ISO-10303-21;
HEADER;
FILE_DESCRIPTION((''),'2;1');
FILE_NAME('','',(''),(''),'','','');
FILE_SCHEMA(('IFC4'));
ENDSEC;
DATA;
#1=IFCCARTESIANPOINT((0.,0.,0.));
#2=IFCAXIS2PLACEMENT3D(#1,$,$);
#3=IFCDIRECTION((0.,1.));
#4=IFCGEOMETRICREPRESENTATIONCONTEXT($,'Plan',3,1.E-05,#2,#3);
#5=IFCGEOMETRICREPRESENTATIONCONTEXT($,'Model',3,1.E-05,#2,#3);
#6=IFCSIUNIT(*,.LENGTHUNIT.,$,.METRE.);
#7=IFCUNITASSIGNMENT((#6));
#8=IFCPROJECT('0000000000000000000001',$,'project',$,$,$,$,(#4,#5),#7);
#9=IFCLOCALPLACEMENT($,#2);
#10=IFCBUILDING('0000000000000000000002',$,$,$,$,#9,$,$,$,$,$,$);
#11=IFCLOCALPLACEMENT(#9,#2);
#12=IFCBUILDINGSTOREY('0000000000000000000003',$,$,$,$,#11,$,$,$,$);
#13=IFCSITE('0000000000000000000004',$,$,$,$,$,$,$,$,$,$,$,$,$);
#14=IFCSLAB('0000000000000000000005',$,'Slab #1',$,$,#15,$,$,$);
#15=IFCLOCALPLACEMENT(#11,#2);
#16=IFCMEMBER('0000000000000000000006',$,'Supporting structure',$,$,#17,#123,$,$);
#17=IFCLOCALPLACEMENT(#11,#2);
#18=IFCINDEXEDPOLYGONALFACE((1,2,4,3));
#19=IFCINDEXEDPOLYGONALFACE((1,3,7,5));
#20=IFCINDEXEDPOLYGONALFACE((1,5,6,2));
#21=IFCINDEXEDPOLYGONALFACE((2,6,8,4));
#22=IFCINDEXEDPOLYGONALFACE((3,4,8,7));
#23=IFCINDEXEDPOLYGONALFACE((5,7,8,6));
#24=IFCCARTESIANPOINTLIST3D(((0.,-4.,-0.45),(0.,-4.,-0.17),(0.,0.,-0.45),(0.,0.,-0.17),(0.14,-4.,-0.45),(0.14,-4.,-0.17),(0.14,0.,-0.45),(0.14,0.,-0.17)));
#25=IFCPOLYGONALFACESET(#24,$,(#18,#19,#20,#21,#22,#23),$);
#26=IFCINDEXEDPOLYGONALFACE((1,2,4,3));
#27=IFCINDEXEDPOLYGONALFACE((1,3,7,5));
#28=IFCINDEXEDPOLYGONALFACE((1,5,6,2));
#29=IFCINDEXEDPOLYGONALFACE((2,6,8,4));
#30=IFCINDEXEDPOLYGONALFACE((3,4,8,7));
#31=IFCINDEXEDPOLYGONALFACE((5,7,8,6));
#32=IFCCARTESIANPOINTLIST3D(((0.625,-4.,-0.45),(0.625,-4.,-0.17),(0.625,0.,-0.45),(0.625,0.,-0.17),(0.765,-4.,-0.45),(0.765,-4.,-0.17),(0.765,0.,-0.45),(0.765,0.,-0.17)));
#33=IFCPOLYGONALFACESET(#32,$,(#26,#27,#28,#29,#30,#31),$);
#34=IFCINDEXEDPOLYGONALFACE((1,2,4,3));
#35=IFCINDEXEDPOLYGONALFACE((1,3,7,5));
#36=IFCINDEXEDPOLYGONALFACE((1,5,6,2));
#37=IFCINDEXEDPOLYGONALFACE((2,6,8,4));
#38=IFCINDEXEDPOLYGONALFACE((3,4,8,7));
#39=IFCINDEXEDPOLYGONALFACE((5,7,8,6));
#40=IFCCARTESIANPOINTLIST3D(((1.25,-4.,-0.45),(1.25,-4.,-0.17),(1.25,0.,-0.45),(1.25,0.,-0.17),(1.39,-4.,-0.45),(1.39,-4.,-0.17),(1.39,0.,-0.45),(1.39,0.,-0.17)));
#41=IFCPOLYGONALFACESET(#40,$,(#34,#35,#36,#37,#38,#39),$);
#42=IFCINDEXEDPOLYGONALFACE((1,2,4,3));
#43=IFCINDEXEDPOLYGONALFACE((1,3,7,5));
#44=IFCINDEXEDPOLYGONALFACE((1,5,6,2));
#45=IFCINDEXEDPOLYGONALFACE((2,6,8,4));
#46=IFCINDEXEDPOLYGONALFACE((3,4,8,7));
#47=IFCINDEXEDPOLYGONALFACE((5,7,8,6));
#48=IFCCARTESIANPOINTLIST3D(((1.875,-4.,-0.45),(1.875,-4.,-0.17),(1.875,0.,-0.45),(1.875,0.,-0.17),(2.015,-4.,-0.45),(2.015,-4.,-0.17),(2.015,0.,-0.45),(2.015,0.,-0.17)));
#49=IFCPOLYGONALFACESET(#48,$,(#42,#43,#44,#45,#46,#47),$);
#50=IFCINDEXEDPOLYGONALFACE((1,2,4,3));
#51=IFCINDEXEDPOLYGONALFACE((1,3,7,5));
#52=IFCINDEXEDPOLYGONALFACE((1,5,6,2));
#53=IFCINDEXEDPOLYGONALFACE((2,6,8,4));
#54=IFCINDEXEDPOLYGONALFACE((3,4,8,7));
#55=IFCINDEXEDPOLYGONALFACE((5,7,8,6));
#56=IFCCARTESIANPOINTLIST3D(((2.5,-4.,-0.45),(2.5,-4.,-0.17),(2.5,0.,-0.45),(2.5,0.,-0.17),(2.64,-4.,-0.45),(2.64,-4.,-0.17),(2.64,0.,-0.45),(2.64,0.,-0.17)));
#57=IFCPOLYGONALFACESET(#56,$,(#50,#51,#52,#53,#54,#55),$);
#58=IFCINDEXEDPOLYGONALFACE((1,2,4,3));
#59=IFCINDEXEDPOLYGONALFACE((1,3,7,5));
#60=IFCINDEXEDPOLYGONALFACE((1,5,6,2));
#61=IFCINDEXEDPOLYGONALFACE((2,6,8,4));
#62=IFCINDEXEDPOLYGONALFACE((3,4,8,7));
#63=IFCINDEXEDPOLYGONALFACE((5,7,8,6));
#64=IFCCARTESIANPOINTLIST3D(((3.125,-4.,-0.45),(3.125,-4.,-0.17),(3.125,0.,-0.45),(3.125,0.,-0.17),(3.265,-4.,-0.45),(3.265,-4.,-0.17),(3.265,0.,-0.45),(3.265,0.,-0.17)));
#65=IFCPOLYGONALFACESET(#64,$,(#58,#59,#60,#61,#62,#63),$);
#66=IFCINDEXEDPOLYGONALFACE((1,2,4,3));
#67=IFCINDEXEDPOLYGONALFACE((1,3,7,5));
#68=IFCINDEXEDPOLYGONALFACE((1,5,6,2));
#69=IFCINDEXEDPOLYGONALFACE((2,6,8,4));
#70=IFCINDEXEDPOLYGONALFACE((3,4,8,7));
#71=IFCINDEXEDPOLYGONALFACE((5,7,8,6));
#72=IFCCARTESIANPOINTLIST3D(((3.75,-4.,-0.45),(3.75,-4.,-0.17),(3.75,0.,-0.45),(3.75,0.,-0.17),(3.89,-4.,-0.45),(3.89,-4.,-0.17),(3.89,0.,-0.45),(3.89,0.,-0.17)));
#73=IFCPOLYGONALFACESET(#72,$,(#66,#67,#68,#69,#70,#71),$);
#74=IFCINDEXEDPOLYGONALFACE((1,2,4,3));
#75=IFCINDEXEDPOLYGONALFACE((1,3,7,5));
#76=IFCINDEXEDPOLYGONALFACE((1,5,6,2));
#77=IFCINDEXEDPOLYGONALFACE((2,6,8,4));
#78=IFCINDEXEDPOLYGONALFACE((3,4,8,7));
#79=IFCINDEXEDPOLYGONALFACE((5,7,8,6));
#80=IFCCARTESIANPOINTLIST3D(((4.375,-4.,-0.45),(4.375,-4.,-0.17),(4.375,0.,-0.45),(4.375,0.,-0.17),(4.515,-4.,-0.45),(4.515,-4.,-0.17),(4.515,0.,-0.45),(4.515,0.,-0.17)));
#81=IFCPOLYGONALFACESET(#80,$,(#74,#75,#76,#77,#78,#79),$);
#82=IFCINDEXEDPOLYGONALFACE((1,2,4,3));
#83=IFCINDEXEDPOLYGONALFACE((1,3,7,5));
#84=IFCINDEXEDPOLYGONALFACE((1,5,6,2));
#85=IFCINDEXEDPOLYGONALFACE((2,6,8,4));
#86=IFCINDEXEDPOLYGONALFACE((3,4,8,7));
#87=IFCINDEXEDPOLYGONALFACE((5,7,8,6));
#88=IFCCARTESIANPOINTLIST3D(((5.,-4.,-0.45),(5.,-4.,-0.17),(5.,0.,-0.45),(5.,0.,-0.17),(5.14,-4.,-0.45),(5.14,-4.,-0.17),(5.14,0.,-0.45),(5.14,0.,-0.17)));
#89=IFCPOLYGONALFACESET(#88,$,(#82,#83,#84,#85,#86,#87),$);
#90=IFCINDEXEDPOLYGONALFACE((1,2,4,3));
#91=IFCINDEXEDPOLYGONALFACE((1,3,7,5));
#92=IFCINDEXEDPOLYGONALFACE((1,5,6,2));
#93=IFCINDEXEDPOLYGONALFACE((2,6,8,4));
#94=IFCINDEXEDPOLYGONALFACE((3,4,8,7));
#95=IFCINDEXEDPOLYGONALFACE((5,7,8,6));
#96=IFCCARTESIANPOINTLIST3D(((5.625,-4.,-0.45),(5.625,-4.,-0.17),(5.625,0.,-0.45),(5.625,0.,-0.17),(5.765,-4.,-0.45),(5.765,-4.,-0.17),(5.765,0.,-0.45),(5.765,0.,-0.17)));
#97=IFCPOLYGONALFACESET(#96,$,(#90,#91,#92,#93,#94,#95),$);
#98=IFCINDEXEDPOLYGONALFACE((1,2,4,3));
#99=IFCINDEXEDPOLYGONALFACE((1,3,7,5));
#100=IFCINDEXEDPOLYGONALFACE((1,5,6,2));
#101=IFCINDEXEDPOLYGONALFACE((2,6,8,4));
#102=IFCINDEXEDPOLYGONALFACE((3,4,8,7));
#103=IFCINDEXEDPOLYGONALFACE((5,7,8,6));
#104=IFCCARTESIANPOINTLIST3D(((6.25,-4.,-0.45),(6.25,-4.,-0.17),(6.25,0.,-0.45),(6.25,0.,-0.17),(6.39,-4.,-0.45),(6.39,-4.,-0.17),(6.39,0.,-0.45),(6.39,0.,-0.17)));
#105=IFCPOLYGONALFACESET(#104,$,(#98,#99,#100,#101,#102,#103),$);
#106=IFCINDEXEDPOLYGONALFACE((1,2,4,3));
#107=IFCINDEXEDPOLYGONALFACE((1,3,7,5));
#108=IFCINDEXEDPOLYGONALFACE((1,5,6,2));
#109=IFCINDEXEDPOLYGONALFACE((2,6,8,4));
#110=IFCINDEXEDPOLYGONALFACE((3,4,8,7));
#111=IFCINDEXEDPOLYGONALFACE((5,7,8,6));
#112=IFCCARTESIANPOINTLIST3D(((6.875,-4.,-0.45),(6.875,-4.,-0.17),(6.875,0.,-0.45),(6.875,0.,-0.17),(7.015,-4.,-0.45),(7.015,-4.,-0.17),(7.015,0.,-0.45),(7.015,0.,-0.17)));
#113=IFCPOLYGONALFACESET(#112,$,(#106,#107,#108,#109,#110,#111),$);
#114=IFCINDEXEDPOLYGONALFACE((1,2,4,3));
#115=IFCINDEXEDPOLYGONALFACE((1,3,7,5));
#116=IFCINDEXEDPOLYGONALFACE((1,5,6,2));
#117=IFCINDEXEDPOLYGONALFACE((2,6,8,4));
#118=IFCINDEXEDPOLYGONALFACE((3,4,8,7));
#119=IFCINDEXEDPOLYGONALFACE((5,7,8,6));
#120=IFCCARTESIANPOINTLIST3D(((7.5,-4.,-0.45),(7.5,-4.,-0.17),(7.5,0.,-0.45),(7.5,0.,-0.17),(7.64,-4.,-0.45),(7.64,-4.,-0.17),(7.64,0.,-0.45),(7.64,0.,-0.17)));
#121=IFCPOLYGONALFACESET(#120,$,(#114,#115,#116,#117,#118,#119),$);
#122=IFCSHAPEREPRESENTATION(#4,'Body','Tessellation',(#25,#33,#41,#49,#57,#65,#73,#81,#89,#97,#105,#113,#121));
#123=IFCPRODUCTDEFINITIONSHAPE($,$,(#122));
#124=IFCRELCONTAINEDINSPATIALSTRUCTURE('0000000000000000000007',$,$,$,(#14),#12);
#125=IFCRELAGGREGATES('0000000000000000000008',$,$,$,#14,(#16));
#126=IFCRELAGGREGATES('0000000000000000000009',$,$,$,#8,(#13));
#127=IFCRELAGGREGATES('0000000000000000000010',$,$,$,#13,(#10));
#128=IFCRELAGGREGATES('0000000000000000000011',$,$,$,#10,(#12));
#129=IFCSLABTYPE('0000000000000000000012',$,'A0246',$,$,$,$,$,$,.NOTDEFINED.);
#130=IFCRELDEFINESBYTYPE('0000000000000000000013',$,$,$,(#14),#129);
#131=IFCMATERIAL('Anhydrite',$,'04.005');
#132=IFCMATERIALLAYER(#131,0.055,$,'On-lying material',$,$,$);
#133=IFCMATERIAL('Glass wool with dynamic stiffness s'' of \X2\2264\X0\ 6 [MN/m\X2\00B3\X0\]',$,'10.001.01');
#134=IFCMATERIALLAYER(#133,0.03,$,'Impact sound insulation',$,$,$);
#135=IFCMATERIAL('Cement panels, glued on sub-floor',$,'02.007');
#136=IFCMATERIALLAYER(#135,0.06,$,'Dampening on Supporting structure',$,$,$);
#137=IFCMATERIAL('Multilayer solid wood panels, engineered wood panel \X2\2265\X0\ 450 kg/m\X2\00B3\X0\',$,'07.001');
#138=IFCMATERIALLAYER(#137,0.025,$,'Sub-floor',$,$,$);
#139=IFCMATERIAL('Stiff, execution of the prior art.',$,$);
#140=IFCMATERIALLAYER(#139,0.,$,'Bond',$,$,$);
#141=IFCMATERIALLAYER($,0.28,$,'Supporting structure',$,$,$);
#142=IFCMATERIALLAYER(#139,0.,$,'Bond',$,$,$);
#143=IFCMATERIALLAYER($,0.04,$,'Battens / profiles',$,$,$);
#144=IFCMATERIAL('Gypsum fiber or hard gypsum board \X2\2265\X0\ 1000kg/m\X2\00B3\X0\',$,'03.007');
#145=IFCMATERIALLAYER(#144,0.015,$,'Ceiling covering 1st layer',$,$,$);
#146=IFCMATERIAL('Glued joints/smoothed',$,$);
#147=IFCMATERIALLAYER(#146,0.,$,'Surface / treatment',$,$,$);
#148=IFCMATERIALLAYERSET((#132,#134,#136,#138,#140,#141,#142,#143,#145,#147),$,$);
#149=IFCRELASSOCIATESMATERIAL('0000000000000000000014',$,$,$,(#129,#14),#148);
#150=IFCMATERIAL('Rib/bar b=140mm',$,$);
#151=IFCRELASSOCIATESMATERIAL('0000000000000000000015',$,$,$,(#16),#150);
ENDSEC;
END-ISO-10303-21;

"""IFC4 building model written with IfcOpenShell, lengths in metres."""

from ifc_helpers import new_model, si_unit, direction, frame, frame_2d, origin, place, context, project, spatial, rectangle, extrude, material, layer, layer_set, type_object, element, aggregate, save


model = new_model("IFC4")

# Units and contexts
plan_context = context("Plan", 3, precision=1e-05, world=origin(), true_north=direction((0.0, 1.0)))
model_context = context("Model", 3, precision=1e-05, world=origin(), true_north=direction((0.0, 1.0)))
ifc_project = project(units=[si_unit("LENGTHUNIT", "METRE")], contexts=[plan_context, model_context])

# Site, building, storey
site = spatial("IfcSite", under=ifc_project)
building_placement = place(None, origin())
building = spatial("IfcBuilding", under=site, at=building_placement)
storey_placement = place(building_placement, origin())
storey = spatial("IfcBuildingStorey", under=building, at=storey_placement)

# Slab, member
ifc_material_1 = material(Name="Anhydrite", Category="04.005")
ifc_layer_1 = layer(ifc_material_1, 0.055, Name="On-lying material")
ifc_material_2 = material(Name="Glass wool with dynamic stiffness s' of ≤ 6 [MN/m³]", Category="10.001.01")
ifc_layer_2 = layer(ifc_material_2, 0.03, Name="Impact sound insulation")
ifc_material_3 = material(Name="Cement panels, glued on sub-floor", Category="02.007")
ifc_layer_3 = layer(ifc_material_3, 0.06, Name="Dampening on Supporting structure")
ifc_material_4 = material(Name="Multilayer solid wood panels, engineered wood panel ≥ 450 kg/m³", Category="07.001")
ifc_layer_4 = layer(ifc_material_4, 0.025, Name="Sub-floor")
ifc_material_5 = material(Name="Stiff, execution of the prior art.")
ifc_layer_5 = layer(ifc_material_5, 0.0, Name="Bond")
ifc_layer_6 = layer(None, 0.28, Name="Supporting structure")
ifc_layer_7 = layer(ifc_material_5, 0.0, Name="Bond")
ifc_layer_8 = layer(None, 0.04, Name="Battens / profiles")
ifc_material_6 = material(Name="Gypsum fiber or hard gypsum board ≥ 1000kg/m³", Category="03.007")
ifc_layer_9 = layer(ifc_material_6, 0.015, Name="Ceiling covering 1st layer")
ifc_material_7 = material(Name="Glued joints/smoothed")
ifc_layer_10 = layer(ifc_material_7, 0.0, Name="Surface / treatment")
ifc_layer_set = layer_set([ifc_layer_1, ifc_layer_2, ifc_layer_3, ifc_layer_4, ifc_layer_5, ifc_layer_6, ifc_layer_7, ifc_layer_8, ifc_layer_9, ifc_layer_10])
slab_type = type_object("IfcSlabType", Name="A0246", PredefinedType="NOTDEFINED", material=ifc_layer_set)
slab_placement = place(None, frame((0.0, 0.0, 0.0), z_axis=(0.0, 0.0, -1.0), x_axis=(1.0, 0.0, 0.0)))
slab = element("IfcSlab", 1, at=slab_placement, inside=storey, type_object=slab_type, material=ifc_layer_set, Name="Slab #1")
ifc_material_8 = material(Name="Rib/bar b=140mm")
member_1_placement = place(slab_placement, origin())
member_1 = element("IfcMember", 2, at=member_1_placement, material=ifc_material_8, Name="Supporting structure", context=plan_context, shape_type="SweptSolid", body=[
    extrude(rectangle(XDim=0.14, YDim=0.28, at=frame_2d((0.07, 0.14), x_axis=(1.0, 0.0))), frame((0.0, 4.0, 0.17), z_axis=(0.0, -1.0, 0.0), x_axis=(1.0, 0.0, 0.0)), (0.0, 0.0, 1.0), 4.0),
    extrude(rectangle(XDim=0.14, YDim=0.28, at=frame_2d((0.07, 0.14), x_axis=(1.0, 0.0))), frame((0.625, 4.0, 0.17), z_axis=(0.0, -1.0, 0.0), x_axis=(1.0, 0.0, 0.0)), (0.0, 0.0, 1.0), 4.0),
    extrude(rectangle(XDim=0.14, YDim=0.28, at=frame_2d((0.07, 0.14), x_axis=(1.0, 0.0))), frame((1.25, 4.0, 0.17), z_axis=(0.0, -1.0, 0.0), x_axis=(1.0, 0.0, 0.0)), (0.0, 0.0, 1.0), 4.0),
    extrude(rectangle(XDim=0.14, YDim=0.28, at=frame_2d((0.07, 0.14), x_axis=(1.0, 0.0))), frame((1.875, 4.0, 0.17), z_axis=(0.0, -1.0, 0.0), x_axis=(1.0, 0.0, 0.0)), (0.0, 0.0, 1.0), 4.0),
    extrude(rectangle(XDim=0.14, YDim=0.28, at=frame_2d((0.07, 0.14), x_axis=(1.0, 0.0))), frame((2.5, 4.0, 0.17), z_axis=(0.0, -1.0, 0.0), x_axis=(1.0, 0.0, 0.0)), (0.0, 0.0, 1.0), 4.0),
    extrude(rectangle(XDim=0.14, YDim=0.28, at=frame_2d((0.07, 0.14), x_axis=(1.0, 0.0))), frame((3.125, 4.0, 0.17), z_axis=(0.0, -1.0, 0.0), x_axis=(1.0, 0.0, 0.0)), (0.0, 0.0, 1.0), 4.0),
    extrude(rectangle(XDim=0.14, YDim=0.28, at=frame_2d((0.07, 0.14), x_axis=(1.0, 0.0))), frame((3.75, 4.0, 0.17), z_axis=(0.0, -1.0, 0.0), x_axis=(1.0, 0.0, 0.0)), (0.0, 0.0, 1.0), 4.0),
    extrude(rectangle(XDim=0.14, YDim=0.28, at=frame_2d((0.07, 0.14), x_axis=(1.0, 0.0))), frame((4.375, 4.0, 0.17), z_axis=(0.0, -1.0, 0.0), x_axis=(1.0, 0.0, 0.0)), (0.0, 0.0, 1.0), 4.0),
    extrude(rectangle(XDim=0.14, YDim=0.28, at=frame_2d((0.07, 0.14), x_axis=(1.0, 0.0))), frame((5.0, 4.0, 0.17), z_axis=(0.0, -1.0, 0.0), x_axis=(1.0, 0.0, 0.0)), (0.0, 0.0, 1.0), 4.0),
    extrude(rectangle(XDim=0.14, YDim=0.28, at=frame_2d((0.07, 0.14), x_axis=(1.0, 0.0))), frame((5.625, 4.0, 0.17), z_axis=(0.0, -1.0, 0.0), x_axis=(1.0, 0.0, 0.0)), (0.0, 0.0, 1.0), 4.0),
    extrude(rectangle(XDim=0.14, YDim=0.28, at=frame_2d((0.07, 0.14), x_axis=(1.0, 0.0))), frame((6.25, 4.0, 0.17), z_axis=(0.0, -1.0, 0.0), x_axis=(1.0, 0.0, 0.0)), (0.0, 0.0, 1.0), 4.0),
    extrude(rectangle(XDim=0.14, YDim=0.28, at=frame_2d((0.07, 0.14), x_axis=(1.0, 0.0))), frame((6.875, 4.0, 0.17), z_axis=(0.0, -1.0, 0.0), x_axis=(1.0, 0.0, 0.0)), (0.0, 0.0, 1.0), 4.0),
    extrude(rectangle(XDim=0.14, YDim=0.28, at=frame_2d((0.07, 0.14), x_axis=(1.0, 0.0))), frame((7.5, 4.0, 0.17), z_axis=(0.0, -1.0, 0.0), x_axis=(1.0, 0.0, 0.0)), (0.0, 0.0, 1.0), 4.0),
])
aggregate(slab, [member_1])

save(model, "model.ifc")
